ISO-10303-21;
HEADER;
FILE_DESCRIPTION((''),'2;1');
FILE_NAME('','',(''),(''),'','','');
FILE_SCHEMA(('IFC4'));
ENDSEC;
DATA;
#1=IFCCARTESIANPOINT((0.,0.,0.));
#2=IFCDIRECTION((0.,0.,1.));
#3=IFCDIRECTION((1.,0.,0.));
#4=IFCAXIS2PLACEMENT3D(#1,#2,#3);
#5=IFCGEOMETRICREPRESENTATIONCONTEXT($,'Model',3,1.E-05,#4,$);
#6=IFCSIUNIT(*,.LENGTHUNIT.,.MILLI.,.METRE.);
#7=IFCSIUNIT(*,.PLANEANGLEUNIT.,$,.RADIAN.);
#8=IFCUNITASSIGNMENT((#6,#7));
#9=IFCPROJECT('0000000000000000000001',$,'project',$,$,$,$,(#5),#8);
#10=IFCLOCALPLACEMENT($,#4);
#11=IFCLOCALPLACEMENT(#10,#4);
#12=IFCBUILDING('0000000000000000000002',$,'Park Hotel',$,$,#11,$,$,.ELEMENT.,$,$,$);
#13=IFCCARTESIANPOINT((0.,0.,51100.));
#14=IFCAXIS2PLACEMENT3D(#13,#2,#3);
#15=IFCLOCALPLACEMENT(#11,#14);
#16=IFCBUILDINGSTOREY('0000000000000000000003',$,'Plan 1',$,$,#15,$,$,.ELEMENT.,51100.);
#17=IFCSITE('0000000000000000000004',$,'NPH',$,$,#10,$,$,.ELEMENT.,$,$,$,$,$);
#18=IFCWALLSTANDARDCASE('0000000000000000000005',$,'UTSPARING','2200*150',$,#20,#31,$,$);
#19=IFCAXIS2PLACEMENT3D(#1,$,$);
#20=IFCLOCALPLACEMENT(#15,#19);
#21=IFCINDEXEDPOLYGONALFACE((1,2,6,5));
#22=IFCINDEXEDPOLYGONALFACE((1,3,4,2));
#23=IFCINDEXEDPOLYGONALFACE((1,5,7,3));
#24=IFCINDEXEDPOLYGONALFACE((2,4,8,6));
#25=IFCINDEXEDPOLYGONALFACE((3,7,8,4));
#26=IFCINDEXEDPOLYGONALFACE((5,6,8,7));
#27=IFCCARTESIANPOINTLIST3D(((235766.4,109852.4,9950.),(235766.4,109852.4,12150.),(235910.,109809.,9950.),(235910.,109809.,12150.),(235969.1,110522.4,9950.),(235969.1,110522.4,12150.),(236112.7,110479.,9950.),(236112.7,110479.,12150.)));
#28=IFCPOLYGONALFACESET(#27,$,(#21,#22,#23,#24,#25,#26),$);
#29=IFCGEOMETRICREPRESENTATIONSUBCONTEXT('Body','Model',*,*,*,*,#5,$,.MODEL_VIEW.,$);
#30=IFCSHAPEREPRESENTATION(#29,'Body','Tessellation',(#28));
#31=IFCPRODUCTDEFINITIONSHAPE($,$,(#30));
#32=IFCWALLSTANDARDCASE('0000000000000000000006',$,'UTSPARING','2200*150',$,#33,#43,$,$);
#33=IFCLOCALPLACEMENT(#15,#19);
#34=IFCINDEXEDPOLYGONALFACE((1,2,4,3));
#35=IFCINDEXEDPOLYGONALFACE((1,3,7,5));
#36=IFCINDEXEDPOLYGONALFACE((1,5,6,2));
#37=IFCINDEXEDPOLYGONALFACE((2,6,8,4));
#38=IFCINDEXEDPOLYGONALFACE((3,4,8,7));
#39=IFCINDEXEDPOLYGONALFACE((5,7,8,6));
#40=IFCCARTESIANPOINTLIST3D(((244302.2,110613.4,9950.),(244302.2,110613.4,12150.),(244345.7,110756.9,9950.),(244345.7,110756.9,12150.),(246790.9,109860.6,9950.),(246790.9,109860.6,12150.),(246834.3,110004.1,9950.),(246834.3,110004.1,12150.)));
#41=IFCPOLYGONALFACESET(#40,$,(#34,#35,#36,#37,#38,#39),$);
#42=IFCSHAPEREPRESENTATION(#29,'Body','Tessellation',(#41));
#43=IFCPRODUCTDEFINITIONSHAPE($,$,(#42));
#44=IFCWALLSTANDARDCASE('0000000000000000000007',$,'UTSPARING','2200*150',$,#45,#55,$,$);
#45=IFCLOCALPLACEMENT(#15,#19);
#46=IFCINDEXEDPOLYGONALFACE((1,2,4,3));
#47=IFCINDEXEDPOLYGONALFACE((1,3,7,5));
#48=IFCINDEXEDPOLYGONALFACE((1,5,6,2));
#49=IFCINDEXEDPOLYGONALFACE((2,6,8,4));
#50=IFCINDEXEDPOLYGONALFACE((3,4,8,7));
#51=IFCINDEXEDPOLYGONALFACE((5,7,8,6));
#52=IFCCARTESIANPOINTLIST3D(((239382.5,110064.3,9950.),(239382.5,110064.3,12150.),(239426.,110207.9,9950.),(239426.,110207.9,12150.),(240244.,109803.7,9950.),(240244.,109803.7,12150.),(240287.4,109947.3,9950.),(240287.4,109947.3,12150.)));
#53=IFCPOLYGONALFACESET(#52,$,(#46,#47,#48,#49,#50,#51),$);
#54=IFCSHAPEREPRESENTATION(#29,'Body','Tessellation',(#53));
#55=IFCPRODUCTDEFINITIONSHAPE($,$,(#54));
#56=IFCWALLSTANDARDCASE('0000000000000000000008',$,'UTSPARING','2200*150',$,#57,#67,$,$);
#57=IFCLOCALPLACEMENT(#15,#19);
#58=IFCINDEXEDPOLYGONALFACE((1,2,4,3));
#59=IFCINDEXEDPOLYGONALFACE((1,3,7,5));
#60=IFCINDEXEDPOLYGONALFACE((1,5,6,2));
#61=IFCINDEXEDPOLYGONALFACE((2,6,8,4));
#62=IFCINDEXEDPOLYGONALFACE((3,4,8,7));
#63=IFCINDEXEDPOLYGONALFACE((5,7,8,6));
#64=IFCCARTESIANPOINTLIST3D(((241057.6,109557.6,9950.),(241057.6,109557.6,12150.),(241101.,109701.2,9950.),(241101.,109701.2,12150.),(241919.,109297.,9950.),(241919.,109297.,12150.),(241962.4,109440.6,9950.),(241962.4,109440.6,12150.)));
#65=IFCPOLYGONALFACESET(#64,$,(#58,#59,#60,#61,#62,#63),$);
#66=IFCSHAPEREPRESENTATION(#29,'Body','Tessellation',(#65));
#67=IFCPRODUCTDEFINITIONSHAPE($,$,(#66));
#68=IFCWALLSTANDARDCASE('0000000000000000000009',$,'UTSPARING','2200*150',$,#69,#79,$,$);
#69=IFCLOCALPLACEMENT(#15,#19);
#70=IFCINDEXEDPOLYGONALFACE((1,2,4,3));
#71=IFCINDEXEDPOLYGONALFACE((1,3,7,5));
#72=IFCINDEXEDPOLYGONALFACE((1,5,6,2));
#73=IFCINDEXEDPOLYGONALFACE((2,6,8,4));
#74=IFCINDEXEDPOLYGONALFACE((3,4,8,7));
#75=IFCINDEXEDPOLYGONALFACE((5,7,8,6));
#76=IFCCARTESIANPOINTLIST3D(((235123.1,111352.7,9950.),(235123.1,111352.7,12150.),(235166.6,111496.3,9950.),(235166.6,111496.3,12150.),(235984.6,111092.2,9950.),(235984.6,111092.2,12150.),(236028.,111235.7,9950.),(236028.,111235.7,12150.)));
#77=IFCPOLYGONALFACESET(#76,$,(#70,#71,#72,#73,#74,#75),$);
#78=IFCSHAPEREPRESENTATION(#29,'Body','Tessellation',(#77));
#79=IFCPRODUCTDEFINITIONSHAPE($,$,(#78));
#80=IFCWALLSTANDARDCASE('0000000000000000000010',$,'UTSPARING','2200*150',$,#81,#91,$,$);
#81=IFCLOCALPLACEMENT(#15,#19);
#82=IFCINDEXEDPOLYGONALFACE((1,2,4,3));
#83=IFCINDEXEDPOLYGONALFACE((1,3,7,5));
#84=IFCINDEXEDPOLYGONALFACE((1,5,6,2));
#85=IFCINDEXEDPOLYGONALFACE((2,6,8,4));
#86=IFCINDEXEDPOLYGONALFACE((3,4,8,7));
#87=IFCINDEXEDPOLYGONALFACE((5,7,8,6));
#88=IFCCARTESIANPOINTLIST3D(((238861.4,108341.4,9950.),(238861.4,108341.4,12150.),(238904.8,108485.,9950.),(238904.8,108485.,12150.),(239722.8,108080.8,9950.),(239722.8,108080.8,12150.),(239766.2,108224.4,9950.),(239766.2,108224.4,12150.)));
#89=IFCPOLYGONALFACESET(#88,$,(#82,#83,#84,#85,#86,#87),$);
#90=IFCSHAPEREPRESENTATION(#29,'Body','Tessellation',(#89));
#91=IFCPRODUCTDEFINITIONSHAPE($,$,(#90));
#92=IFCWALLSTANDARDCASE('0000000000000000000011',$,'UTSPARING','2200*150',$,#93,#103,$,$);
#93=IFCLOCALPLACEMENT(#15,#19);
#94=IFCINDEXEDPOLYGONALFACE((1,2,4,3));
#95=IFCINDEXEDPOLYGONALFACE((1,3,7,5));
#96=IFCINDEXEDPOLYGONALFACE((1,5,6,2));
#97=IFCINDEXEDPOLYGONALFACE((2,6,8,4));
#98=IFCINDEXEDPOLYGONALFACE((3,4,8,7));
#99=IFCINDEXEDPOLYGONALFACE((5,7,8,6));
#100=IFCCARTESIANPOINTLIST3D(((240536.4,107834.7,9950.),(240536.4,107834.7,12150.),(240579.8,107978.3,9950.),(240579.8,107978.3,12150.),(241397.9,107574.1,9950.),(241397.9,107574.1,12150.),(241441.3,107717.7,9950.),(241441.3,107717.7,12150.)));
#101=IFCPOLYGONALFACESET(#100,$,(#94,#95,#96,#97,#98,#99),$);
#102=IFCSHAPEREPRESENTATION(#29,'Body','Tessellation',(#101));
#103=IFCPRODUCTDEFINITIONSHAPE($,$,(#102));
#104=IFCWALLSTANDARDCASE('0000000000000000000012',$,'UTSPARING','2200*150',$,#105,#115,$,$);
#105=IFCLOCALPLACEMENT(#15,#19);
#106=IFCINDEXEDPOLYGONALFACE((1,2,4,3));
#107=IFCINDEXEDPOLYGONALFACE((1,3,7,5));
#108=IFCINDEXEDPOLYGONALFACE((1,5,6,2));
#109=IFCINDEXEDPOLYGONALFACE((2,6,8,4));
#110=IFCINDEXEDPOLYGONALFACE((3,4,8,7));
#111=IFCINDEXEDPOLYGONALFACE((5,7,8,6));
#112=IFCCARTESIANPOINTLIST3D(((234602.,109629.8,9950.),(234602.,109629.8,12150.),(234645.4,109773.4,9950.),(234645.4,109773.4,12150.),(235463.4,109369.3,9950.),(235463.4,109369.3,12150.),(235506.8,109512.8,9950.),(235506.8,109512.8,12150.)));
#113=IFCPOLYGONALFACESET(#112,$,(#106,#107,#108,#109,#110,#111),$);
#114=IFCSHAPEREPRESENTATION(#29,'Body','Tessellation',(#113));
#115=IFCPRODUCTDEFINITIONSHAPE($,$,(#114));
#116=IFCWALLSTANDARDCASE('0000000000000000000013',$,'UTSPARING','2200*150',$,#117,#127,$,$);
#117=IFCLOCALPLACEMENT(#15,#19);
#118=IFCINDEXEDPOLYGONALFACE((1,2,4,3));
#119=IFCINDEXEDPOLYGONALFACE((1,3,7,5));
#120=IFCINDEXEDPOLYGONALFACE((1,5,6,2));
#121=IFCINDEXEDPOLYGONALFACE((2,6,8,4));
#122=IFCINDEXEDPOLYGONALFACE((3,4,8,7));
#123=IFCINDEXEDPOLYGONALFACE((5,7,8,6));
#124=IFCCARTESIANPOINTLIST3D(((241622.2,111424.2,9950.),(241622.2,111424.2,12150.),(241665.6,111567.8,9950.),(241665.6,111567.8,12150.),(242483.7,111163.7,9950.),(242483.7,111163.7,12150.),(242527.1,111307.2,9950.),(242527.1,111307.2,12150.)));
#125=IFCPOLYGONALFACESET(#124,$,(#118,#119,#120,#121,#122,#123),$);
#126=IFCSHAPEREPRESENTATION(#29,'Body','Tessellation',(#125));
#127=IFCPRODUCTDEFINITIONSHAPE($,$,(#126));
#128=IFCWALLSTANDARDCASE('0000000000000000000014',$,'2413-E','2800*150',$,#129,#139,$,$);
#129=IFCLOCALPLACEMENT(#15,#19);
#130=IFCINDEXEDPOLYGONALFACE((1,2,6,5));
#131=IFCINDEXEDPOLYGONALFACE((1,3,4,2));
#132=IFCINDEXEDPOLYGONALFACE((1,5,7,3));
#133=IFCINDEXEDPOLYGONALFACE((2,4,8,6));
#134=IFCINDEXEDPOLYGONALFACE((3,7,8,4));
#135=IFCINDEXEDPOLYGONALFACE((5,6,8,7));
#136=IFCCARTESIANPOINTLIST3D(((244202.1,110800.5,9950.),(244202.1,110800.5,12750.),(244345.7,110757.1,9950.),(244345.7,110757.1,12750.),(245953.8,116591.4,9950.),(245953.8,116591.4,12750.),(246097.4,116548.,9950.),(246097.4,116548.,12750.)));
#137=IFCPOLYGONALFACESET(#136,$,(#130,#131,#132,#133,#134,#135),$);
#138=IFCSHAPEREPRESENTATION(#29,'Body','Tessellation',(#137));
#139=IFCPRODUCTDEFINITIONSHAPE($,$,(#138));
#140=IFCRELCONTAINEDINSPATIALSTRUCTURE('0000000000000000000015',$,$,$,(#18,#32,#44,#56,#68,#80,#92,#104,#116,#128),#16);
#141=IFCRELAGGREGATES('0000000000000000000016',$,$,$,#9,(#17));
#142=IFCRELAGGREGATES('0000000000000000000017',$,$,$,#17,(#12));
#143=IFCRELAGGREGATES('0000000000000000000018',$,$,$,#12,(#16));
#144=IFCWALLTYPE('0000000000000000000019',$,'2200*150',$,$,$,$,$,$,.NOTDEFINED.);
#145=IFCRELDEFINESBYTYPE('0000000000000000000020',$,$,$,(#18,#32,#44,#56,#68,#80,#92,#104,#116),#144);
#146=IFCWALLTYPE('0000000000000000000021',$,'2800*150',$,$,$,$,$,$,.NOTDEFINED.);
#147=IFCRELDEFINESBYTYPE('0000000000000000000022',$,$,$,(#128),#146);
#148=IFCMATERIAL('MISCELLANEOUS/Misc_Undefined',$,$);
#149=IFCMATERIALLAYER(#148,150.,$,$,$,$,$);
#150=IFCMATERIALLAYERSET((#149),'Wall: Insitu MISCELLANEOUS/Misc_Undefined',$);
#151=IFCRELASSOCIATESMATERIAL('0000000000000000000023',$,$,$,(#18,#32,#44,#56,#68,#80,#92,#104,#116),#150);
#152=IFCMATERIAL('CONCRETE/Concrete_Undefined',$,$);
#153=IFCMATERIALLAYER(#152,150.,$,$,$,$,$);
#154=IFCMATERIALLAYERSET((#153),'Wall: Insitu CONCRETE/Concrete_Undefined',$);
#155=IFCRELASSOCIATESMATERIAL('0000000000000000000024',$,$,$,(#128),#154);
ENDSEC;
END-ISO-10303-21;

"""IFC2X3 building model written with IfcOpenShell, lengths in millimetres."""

from ifc_helpers import new_model, si_unit, frame, frame_2d, origin_with_axes, place, context, subcontext, project, spatial, rectangle, extrude, material, layer, layer_set, layer_usage, type_object, element, save


model = new_model("IFC2X3")

# Units and contexts
model_context = context("Model", 3, precision=1e-05, world=origin_with_axes())
body_context = subcontext(model_context, "Body", "Model", "MODEL_VIEW")
ifc_project = project(units=[si_unit("LENGTHUNIT", "METRE", prefix="MILLI"), si_unit("PLANEANGLEUNIT", "RADIAN")], contexts=[model_context])

# Site, building, storey
site_placement = place(None, origin_with_axes())
site = spatial("IfcSite", under=ifc_project, at=site_placement, Name="NPH", CompositionType="ELEMENT")
building_placement = place(site_placement, origin_with_axes())
building = spatial("IfcBuilding", under=site, at=building_placement, Name="Park Hotel", CompositionType="ELEMENT")
storey_placement = place(building_placement, frame((0.0, 0.0, 51100.0), z_axis=(0.0, 0.0, 1.0), x_axis=(1.0, 0.0, 0.0)))
storey = spatial("IfcBuildingStorey", under=building, at=storey_placement, Name="Plan 1", CompositionType="ELEMENT", Elevation=51100.0)

# Walls
ifc_material_1 = material(Name="CONCRETE/Concrete_Undefined")
ifc_layer_1 = layer(ifc_material_1, 150.0)
ifc_layer_set_1 = layer_set([ifc_layer_1], Name="Wall: Insitu CONCRETE/Concrete_Undefined")
ifc_material_2 = material(Name="MISCELLANEOUS/Misc_Undefined")
ifc_layer_2 = layer(ifc_material_2, 150.0)
ifc_layer_set_2 = layer_set([ifc_layer_2], Name="Wall: Insitu MISCELLANEOUS/Misc_Undefined")
wall_type_1 = type_object("IfcWallType", Name="2200*150", PredefinedType="NOTDEFINED")
ifc_layer_usage_1 = layer_usage(ifc_layer_set_2, "AXIS2", "POSITIVE", -75.0)
wall_1_placement = place(storey_placement, frame((235838.2, 109830.7, 9950.0), z_axis=(0.0, 0.0, 1.0), x_axis=(0.289542, 0.957165, 0.0)))
element("IfcWallStandardCase", 1, at=wall_1_placement, inside=storey, type_object=wall_type_1, material=ifc_layer_usage_1, Name="UTSPARING", Description="2200*150", context=body_context, shape_type="SweptSolid", body=[
    extrude(rectangle(XDim=700.0, YDim=150.0, at=frame_2d((0.0, 350.0), x_axis=(0.0, -1.0))), frame((0.0, 0.0, 0.0), z_axis=(0.0, 0.0, 1.0), x_axis=(0.0, -1.0, 0.0)), (0.0, 0.0, 1.0), 2200.0),
])
ifc_layer_usage_2 = layer_usage(ifc_layer_set_2, "AXIS2", "POSITIVE", -75.0)
wall_2_placement = place(storey_placement, frame((244324.0, 110685.2, 9950.0), z_axis=(0.0, 0.0, 1.0), x_axis=(0.957166, -0.289539, 0.0)))
element("IfcWallStandardCase", 2, at=wall_2_placement, inside=storey, type_object=wall_type_1, material=ifc_layer_usage_2, Name="UTSPARING", Description="2200*150", context=body_context, shape_type="SweptSolid", body=[
    extrude(rectangle(XDim=2600.0, YDim=150.0, at=frame_2d((0.0, 1300.0), x_axis=(0.0, -1.0))), frame((0.0, 0.0, 0.0), z_axis=(0.0, 0.0, 1.0), x_axis=(0.0, -1.0, 0.0)), (0.0, 0.0, 1.0), 2200.0),
])
ifc_layer_usage_3 = layer_usage(ifc_layer_set_2, "AXIS2", "POSITIVE", -75.0)
wall_3_placement = place(storey_placement, frame((239404.2, 110136.1, 9950.0), z_axis=(0.0, 0.0, 1.0), x_axis=(0.957166, -0.289541, 0.0)))
element("IfcWallStandardCase", 3, at=wall_3_placement, inside=storey, type_object=wall_type_1, material=ifc_layer_usage_3, Name="UTSPARING", Description="2200*150", context=body_context, shape_type="SweptSolid", body=[
    extrude(rectangle(XDim=900.0, YDim=150.0, at=frame_2d((0.0, 450.0), x_axis=(0.0, -1.0))), frame((0.0, 0.0, 0.0), z_axis=(0.0, 0.0, 1.0), x_axis=(0.0, -1.0, 0.0)), (0.0, 0.0, 1.0), 2200.0),
])
ifc_layer_usage_4 = layer_usage(ifc_layer_set_2, "AXIS2", "POSITIVE", -75.0)
wall_4_placement = place(storey_placement, frame((241079.3, 109629.4, 9950.0), z_axis=(0.0, 0.0, 1.0), x_axis=(0.957166, -0.289541, 0.0)))
element("IfcWallStandardCase", 4, at=wall_4_placement, inside=storey, type_object=wall_type_1, material=ifc_layer_usage_4, Name="UTSPARING", Description="2200*150", context=body_context, shape_type="SweptSolid", body=[
    extrude(rectangle(XDim=900.0, YDim=150.0, at=frame_2d((0.0, 450.0), x_axis=(0.0, -1.0))), frame((0.0, 0.0, 0.0), z_axis=(0.0, 0.0, 1.0), x_axis=(0.0, -1.0, 0.0)), (0.0, 0.0, 1.0), 2200.0),
])
ifc_layer_usage_5 = layer_usage(ifc_layer_set_2, "AXIS2", "POSITIVE", -75.0)
wall_5_placement = place(storey_placement, frame((235144.9, 111424.5, 9950.0), z_axis=(0.0, 0.0, 1.0), x_axis=(0.957166, -0.289541, 0.0)))
element("IfcWallStandardCase", 5, at=wall_5_placement, inside=storey, type_object=wall_type_1, material=ifc_layer_usage_5, Name="UTSPARING", Description="2200*150", context=body_context, shape_type="SweptSolid", body=[
    extrude(rectangle(XDim=900.0, YDim=150.0, at=frame_2d((0.0, 450.0), x_axis=(0.0, -1.0))), frame((0.0, 0.0, 0.0), z_axis=(0.0, 0.0, 1.0), x_axis=(0.0, -1.0, 0.0)), (0.0, 0.0, 1.0), 2200.0),
])
ifc_layer_usage_6 = layer_usage(ifc_layer_set_2, "AXIS2", "POSITIVE", -75.0)
wall_6_placement = place(storey_placement, frame((238883.1, 108413.2, 9950.0), z_axis=(0.0, 0.0, 1.0), x_axis=(0.957166, -0.289541, 0.0)))
element("IfcWallStandardCase", 6, at=wall_6_placement, inside=storey, type_object=wall_type_1, material=ifc_layer_usage_6, Name="UTSPARING", Description="2200*150", context=body_context, shape_type="SweptSolid", body=[
    extrude(rectangle(XDim=900.0, YDim=150.0, at=frame_2d((0.0, 450.0), x_axis=(0.0, -1.0))), frame((0.0, 0.0, 0.0), z_axis=(0.0, 0.0, 1.0), x_axis=(0.0, -1.0, 0.0)), (0.0, 0.0, 1.0), 2200.0),
])
ifc_layer_usage_7 = layer_usage(ifc_layer_set_2, "AXIS2", "POSITIVE", -75.0)
wall_7_placement = place(storey_placement, frame((240558.1, 107906.5, 9950.0), z_axis=(0.0, 0.0, 1.0), x_axis=(0.957166, -0.289541, 0.0)))
element("IfcWallStandardCase", 7, at=wall_7_placement, inside=storey, type_object=wall_type_1, material=ifc_layer_usage_7, Name="UTSPARING", Description="2200*150", context=body_context, shape_type="SweptSolid", body=[
    extrude(rectangle(XDim=900.0, YDim=150.0, at=frame_2d((0.0, 450.0), x_axis=(0.0, -1.0))), frame((0.0, 0.0, 0.0), z_axis=(0.0, 0.0, 1.0), x_axis=(0.0, -1.0, 0.0)), (0.0, 0.0, 1.0), 2200.0),
])
ifc_layer_usage_8 = layer_usage(ifc_layer_set_2, "AXIS2", "POSITIVE", -75.0)
wall_8_placement = place(storey_placement, frame((234623.7, 109701.6, 9950.0), z_axis=(0.0, 0.0, 1.0), x_axis=(0.957166, -0.289541, 0.0)))
element("IfcWallStandardCase", 8, at=wall_8_placement, inside=storey, type_object=wall_type_1, material=ifc_layer_usage_8, Name="UTSPARING", Description="2200*150", context=body_context, shape_type="SweptSolid", body=[
    extrude(rectangle(XDim=900.0, YDim=150.0, at=frame_2d((0.0, 450.0), x_axis=(0.0, -1.0))), frame((0.0, 0.0, 0.0), z_axis=(0.0, 0.0, 1.0), x_axis=(0.0, -1.0, 0.0)), (0.0, 0.0, 1.0), 2200.0),
])
ifc_layer_usage_9 = layer_usage(ifc_layer_set_2, "AXIS2", "POSITIVE", -75.0)
wall_9_placement = place(storey_placement, frame((241643.9, 111496.0, 9950.0), z_axis=(0.0, 0.0, 1.0), x_axis=(0.957166, -0.289541, 0.0)))
element("IfcWallStandardCase", 9, at=wall_9_placement, inside=storey, type_object=wall_type_1, material=ifc_layer_usage_9, Name="UTSPARING", Description="2200*150", context=body_context, shape_type="SweptSolid", body=[
    extrude(rectangle(XDim=900.0, YDim=150.0, at=frame_2d((0.0, 450.0), x_axis=(0.0, -1.0))), frame((0.0, 0.0, 0.0), z_axis=(0.0, 0.0, 1.0), x_axis=(0.0, -1.0, 0.0)), (0.0, 0.0, 1.0), 2200.0),
])
ifc_layer_usage_10 = layer_usage(ifc_layer_set_1, "AXIS2", "POSITIVE", -75.0)
wall_type_2 = type_object("IfcWallType", Name="2800*150", PredefinedType="NOTDEFINED")
wall_10_placement = place(storey_placement, frame((244273.9, 110778.8, 9950.0), z_axis=(0.0, 0.0, 1.0), x_axis=(0.289537, 0.957167, 0.0)))
element("IfcWallStandardCase", 10, at=wall_10_placement, inside=storey, type_object=wall_type_2, material=ifc_layer_usage_10, Name="2413-E", Description="2800*150", context=body_context, shape_type="SweptSolid", body=[
    extrude(rectangle(XDim=6050.0, YDim=150.0, at=frame_2d((0.0, 3025.0), x_axis=(0.0, -1.0))), frame((0.0, 0.0, 0.0), z_axis=(0.0, 0.0, 1.0), x_axis=(0.0, -1.0, 0.0)), (0.0, 0.0, 1.0), 2800.0),
])

save(model, "model.ifc")
